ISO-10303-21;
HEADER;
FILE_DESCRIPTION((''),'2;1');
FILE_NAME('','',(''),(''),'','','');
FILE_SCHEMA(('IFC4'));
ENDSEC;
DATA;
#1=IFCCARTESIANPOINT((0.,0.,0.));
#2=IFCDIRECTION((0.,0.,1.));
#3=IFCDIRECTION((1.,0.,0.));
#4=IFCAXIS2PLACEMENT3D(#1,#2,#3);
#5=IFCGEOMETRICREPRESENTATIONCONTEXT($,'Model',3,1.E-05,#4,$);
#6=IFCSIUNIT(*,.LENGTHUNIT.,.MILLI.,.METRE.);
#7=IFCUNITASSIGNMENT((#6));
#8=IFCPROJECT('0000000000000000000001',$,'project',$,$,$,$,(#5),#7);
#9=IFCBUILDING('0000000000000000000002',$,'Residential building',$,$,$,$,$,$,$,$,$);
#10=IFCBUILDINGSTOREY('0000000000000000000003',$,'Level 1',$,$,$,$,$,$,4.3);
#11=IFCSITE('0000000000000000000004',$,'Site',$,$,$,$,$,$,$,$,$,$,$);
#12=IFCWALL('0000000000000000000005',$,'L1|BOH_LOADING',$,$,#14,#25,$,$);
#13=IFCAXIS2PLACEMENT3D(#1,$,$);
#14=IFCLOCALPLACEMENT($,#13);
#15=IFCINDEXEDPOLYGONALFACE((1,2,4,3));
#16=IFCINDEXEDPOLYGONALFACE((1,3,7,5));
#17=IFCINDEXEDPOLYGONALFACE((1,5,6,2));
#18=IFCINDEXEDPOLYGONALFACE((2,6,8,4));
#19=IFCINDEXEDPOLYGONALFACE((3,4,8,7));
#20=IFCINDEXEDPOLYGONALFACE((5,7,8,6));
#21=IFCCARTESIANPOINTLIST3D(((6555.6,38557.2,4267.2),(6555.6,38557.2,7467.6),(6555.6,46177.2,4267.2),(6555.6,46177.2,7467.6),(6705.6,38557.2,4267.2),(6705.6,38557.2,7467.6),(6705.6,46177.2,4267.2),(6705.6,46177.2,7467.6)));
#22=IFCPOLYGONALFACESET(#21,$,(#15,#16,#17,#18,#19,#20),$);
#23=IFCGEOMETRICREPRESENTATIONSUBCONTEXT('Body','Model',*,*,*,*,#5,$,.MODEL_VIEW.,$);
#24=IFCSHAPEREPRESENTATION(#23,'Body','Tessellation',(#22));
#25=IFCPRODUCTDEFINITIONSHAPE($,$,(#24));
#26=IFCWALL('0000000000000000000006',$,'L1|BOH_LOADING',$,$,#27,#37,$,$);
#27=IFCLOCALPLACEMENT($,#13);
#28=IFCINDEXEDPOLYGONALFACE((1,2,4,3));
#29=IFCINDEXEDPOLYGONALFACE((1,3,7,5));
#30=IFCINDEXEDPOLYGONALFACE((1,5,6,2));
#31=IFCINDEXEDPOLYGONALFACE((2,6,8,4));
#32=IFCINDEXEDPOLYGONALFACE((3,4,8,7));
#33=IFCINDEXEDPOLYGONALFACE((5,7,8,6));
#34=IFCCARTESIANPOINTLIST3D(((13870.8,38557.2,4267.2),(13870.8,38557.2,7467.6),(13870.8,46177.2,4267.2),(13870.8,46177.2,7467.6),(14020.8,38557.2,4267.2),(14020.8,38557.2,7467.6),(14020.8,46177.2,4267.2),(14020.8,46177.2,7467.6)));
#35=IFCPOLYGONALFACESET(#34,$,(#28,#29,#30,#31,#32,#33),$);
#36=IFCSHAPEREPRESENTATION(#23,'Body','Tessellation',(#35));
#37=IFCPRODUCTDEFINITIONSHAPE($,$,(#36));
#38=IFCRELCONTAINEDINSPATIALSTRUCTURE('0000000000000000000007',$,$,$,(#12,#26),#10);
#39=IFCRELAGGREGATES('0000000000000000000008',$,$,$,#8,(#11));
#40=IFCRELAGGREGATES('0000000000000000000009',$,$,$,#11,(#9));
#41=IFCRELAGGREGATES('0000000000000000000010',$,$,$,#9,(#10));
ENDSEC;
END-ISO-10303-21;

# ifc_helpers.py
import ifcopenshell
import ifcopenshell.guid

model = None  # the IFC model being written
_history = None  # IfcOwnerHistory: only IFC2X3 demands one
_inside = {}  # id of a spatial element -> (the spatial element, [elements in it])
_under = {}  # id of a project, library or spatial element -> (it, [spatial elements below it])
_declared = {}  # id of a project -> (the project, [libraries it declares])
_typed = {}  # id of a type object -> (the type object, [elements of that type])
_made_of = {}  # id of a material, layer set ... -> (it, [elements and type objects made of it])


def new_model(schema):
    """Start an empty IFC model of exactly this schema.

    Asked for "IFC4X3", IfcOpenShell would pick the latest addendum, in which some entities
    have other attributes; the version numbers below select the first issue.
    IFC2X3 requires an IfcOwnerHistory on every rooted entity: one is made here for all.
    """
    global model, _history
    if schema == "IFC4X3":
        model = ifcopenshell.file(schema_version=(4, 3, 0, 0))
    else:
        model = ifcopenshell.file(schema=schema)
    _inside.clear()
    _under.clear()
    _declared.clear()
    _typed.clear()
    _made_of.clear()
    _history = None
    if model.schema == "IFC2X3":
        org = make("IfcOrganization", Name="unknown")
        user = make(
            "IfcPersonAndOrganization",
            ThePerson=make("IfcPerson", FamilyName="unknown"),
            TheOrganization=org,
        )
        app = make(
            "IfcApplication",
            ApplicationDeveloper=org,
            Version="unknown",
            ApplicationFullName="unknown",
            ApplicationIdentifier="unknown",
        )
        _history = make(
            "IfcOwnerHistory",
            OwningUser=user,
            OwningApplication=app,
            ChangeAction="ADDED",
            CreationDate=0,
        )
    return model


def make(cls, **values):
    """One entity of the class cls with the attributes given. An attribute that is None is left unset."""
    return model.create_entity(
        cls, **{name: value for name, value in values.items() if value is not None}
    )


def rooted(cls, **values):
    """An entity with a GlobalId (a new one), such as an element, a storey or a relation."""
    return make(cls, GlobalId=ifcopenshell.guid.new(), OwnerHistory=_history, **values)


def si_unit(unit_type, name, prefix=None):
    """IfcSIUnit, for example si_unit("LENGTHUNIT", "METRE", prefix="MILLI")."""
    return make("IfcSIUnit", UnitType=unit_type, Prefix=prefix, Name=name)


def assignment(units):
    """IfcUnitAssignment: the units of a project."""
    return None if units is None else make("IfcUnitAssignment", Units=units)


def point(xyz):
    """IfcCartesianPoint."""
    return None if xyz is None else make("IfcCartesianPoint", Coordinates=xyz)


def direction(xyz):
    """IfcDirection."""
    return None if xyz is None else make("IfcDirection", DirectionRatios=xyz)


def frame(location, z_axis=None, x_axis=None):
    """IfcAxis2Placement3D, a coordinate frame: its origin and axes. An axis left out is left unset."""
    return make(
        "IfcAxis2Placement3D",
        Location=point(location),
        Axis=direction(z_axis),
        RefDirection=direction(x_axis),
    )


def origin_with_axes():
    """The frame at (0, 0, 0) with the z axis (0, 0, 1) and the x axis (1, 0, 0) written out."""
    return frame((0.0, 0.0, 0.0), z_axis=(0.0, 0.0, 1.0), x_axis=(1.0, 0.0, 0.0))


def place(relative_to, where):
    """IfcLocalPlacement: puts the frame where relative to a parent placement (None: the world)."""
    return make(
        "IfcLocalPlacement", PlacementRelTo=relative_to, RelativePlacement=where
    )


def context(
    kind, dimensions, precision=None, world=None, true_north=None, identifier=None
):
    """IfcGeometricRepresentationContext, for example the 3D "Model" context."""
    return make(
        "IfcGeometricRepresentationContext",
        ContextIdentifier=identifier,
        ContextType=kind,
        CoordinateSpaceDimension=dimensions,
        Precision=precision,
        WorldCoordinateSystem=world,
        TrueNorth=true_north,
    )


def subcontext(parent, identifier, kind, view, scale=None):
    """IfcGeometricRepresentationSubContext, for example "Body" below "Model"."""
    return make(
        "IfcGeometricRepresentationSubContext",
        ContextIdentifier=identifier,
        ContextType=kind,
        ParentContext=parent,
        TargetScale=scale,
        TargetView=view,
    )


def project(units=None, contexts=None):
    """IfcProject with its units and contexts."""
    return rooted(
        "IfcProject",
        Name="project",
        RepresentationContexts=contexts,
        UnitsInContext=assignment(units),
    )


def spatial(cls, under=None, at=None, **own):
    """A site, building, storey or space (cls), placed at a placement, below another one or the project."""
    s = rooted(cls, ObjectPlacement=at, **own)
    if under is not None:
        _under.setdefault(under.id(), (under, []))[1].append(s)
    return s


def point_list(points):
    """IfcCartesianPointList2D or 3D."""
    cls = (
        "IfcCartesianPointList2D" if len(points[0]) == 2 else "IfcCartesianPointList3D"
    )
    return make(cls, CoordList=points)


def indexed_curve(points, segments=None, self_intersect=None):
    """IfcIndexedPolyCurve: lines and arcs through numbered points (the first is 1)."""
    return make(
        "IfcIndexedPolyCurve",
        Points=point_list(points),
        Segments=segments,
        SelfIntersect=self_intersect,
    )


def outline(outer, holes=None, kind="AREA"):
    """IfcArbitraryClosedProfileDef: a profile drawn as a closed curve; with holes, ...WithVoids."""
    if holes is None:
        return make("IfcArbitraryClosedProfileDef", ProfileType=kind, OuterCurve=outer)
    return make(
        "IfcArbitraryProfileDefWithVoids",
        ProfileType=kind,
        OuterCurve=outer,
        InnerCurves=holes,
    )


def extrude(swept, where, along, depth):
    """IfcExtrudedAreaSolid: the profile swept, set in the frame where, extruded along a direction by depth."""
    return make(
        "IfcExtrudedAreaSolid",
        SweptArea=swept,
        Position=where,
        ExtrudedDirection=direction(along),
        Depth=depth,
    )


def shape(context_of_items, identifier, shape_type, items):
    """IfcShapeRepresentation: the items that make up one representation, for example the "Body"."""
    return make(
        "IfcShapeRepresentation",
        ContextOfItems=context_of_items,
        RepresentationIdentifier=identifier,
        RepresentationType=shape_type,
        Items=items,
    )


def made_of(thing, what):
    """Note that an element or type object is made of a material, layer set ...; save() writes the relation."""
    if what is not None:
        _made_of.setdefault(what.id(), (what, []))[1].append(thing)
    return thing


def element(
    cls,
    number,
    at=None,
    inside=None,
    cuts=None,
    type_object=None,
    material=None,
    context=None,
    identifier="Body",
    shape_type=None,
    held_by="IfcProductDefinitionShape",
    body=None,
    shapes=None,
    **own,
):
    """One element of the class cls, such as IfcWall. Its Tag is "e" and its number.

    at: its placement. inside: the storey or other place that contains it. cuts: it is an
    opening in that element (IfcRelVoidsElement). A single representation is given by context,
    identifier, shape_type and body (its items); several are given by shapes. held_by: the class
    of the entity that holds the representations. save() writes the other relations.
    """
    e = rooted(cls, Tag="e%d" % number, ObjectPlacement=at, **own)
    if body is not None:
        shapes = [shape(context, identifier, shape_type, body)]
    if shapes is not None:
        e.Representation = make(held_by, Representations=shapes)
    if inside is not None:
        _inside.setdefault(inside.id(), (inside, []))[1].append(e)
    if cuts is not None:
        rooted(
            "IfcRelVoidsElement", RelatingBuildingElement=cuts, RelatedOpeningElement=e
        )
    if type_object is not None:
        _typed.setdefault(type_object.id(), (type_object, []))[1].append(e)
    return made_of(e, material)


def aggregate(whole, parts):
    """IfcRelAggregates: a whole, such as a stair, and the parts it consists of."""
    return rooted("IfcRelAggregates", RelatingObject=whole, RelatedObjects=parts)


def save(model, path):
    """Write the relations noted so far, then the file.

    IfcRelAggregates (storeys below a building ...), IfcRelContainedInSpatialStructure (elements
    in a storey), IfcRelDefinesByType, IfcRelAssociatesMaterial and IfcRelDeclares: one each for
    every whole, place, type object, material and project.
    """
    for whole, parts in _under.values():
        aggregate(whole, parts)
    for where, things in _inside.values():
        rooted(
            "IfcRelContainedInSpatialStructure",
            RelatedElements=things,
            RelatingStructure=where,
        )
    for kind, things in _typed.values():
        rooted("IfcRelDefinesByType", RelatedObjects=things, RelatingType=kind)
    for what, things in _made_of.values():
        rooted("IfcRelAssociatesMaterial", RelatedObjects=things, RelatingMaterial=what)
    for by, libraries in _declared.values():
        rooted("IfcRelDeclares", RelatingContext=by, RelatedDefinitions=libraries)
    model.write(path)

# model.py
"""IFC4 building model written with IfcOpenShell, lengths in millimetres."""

from ifc_helpers import new_model, si_unit, frame, origin_with_axes, place, context, subcontext, project, spatial, indexed_curve, outline, extrude, element, save


model = new_model("IFC4")

# Units and contexts
model_context = context("Model", 3, precision=1e-05, world=origin_with_axes())
body_context = subcontext(model_context, "Body", "Model", "MODEL_VIEW")
ifc_project = project(units=[si_unit("LENGTHUNIT", "METRE", prefix="MILLI")], contexts=[model_context])

# Site, building, storey
site = spatial("IfcSite", under=ifc_project, Name="Site")
building = spatial("IfcBuilding", under=site, Name="Residential building")
storey = spatial("IfcBuildingStorey", under=building, Name="Level 1", Elevation=4.3)

# Walls
for number, where, z_axis, x_axis, name in (
    (1, (6705.6, 38557.2, 4267.2), (0.0, 0.0, 1.0), (0.0, 1.0, 0.0), "L1|BOH_LOADING"),
    (2, (14020.8, 38557.2, 4267.2), (0.0, 0.0, 1.0), (0.0, 1.0, 0.0), "L1|BOH_LOADING"),
):
    element("IfcWall", number, at=place(None, frame(where, z_axis=z_axis, x_axis=x_axis)), inside=storey, Name=name, context=body_context, shape_type="SweptSolid", body=[
        extrude(outline(indexed_curve([(0.0, 0.0), (0.0, 150.0), (7620.0, 150.0), (7620.0, 0.0), (0.0, 0.0)], self_intersect=False)), origin_with_axes(), (0.0, 0.0, 1.0), 3200.4),
    ])

save(model, "model.ifc")
